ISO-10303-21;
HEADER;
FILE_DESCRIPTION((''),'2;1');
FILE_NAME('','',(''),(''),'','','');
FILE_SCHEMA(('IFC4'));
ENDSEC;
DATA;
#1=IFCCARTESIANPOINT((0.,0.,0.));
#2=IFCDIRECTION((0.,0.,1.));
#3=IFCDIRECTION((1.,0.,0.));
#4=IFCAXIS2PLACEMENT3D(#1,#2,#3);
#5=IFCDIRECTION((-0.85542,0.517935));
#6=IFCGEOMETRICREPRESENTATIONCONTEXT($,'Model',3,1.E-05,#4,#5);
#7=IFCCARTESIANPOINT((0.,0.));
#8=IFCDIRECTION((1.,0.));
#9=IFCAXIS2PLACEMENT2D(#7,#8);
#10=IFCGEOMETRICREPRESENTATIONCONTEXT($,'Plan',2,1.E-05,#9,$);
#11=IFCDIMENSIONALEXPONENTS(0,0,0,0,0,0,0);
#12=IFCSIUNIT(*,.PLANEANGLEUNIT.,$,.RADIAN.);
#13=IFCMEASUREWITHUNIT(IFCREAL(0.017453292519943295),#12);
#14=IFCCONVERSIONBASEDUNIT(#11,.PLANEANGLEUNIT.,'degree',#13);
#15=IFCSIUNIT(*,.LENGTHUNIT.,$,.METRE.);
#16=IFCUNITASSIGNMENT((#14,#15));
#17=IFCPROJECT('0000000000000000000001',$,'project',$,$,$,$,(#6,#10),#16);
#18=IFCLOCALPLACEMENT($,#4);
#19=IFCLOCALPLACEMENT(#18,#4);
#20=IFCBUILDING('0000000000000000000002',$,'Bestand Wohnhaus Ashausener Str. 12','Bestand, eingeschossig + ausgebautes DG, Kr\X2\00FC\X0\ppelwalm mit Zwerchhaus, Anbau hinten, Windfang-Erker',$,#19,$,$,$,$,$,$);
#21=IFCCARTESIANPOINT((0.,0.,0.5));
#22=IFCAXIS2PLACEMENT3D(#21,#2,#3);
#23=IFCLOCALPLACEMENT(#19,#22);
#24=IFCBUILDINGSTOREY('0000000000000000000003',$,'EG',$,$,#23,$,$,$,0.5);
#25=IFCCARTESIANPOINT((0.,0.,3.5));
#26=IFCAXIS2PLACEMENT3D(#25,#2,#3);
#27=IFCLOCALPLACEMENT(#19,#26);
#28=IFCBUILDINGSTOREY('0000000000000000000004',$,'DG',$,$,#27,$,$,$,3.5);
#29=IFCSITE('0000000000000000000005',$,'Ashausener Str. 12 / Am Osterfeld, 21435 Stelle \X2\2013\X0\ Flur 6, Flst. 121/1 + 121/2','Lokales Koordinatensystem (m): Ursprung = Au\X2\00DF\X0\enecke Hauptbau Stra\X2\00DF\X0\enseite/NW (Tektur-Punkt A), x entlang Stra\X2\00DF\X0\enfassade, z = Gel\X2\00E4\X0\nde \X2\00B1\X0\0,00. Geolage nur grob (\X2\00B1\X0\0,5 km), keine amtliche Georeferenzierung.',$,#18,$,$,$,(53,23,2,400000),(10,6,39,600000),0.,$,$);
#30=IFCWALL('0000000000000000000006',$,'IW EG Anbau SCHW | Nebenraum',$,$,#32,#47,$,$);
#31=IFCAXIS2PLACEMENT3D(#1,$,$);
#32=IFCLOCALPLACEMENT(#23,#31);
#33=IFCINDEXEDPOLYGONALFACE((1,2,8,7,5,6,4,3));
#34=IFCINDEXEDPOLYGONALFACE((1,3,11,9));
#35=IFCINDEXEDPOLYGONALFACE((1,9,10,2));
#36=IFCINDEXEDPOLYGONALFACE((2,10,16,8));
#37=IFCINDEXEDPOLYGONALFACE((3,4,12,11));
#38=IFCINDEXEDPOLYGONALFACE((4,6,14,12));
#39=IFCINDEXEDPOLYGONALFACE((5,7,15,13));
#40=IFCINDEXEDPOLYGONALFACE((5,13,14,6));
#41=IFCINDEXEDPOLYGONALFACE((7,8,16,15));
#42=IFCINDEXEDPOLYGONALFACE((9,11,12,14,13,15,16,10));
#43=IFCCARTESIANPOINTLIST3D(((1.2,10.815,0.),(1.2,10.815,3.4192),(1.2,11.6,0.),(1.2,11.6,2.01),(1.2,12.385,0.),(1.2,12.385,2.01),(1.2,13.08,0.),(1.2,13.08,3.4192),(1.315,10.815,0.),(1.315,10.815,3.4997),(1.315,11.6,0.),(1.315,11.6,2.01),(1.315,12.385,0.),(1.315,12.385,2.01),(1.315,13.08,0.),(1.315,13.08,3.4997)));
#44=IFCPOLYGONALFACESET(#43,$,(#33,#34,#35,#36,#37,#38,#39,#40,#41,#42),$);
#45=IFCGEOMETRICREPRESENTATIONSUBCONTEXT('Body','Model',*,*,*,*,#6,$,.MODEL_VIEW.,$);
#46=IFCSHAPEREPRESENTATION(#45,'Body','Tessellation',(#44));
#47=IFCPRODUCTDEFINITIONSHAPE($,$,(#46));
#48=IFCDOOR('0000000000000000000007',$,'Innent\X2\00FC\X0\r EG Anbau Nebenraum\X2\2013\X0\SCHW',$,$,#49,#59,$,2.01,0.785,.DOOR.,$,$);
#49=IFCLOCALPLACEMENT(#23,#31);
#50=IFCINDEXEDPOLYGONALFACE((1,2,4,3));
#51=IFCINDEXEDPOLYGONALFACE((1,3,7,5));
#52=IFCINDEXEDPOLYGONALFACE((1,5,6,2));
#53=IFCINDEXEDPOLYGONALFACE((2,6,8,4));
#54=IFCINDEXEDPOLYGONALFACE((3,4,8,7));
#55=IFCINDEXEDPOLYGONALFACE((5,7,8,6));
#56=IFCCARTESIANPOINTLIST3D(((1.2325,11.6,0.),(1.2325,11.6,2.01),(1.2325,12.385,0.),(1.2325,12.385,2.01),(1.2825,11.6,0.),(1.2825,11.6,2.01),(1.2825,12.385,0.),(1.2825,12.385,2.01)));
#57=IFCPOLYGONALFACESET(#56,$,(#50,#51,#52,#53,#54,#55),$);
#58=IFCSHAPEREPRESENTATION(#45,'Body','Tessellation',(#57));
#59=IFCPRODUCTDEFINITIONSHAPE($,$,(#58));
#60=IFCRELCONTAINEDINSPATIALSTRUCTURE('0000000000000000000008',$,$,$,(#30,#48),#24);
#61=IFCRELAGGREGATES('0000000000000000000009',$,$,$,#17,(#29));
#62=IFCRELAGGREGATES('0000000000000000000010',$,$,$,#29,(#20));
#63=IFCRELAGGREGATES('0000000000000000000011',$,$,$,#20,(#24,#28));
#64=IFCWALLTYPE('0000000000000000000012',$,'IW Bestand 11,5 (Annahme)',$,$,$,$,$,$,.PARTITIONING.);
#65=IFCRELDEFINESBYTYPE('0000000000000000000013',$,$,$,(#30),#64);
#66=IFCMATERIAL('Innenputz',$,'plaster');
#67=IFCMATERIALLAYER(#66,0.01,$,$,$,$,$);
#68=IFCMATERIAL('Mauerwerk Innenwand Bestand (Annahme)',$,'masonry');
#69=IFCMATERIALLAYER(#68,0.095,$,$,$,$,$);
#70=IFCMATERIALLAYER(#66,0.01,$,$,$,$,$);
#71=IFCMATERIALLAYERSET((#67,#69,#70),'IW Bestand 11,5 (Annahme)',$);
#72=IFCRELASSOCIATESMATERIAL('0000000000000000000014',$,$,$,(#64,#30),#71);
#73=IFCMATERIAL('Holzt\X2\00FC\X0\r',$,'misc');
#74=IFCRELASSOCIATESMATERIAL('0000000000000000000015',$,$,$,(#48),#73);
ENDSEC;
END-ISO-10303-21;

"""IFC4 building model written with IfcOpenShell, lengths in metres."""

from ifc_helpers import new_model, entity, si_unit, converted_unit, direction, frame, origin_with_axes, origin_2d_with_axis, place, context, subcontext, project, spatial, indexed_curve, outline, extrude, clip, halfspace, material, layer, layer_set, layer_usage, type_object, element, fill, save


model = new_model("IFC4")

# Units and contexts
model_context = context("Model", 3, precision=1e-05, world=origin_with_axes(), true_north=direction((-0.85542, 0.517935)))
plan_context = context("Plan", 2, precision=1e-05, world=origin_2d_with_axis())
body_context = subcontext(model_context, "Body", "Model", "MODEL_VIEW")
ifc_project = project(units=[converted_unit("PLANEANGLEUNIT", "degree", entity("IfcReal", 0.017453292519943295), si_unit("PLANEANGLEUNIT", "RADIAN"), dimensions=[0, 0, 0, 0, 0, 0, 0]), si_unit("LENGTHUNIT", "METRE")], contexts=[model_context, plan_context])

# Site, building, storey
site_placement = place(None, origin_with_axes())
site = spatial("IfcSite", under=ifc_project, at=site_placement, Name="Ashausener Str. 12 / Am Osterfeld, 21435 Stelle – Flur 6, Flst. 121/1 + 121/2", Description="Lokales Koordinatensystem (m): Ursprung = Außenecke Hauptbau Straßenseite/NW (Tektur-Punkt A), x entlang Straßenfassade, z = Gelände ±0,00. Geolage nur grob (±0,5 km), keine amtliche Georeferenzierung.", RefLatitude=(53, 23, 2, 400000), RefLongitude=(10, 6, 39, 600000), RefElevation=0.0)
building_placement = place(site_placement, origin_with_axes())
building = spatial("IfcBuilding", under=site, at=building_placement, Name="Bestand Wohnhaus Ashausener Str. 12", Description="Bestand, eingeschossig + ausgebautes DG, Krüppelwalm mit Zwerchhaus, Anbau hinten, Windfang-Erker")
storey_1_placement = place(building_placement, frame((0.0, 0.0, 0.5), z_axis=(0.0, 0.0, 1.0), x_axis=(1.0, 0.0, 0.0)))
storey_1 = spatial("IfcBuildingStorey", under=building, at=storey_1_placement, Name="EG", Elevation=0.5)

# Shared definitions
storey_2_placement = place(building_placement, frame((0.0, 0.0, 3.5), z_axis=(0.0, 0.0, 1.0), x_axis=(1.0, 0.0, 0.0)))
storey_2 = spatial("IfcBuildingStorey", under=building, at=storey_2_placement, Name="DG", Elevation=3.5)

# Wall, opening, door
ifc_material_1 = material(Name="Innenputz", Category="plaster")
ifc_layer_1 = layer(ifc_material_1, 0.01)
ifc_material_2 = material(Name="Mauerwerk Innenwand Bestand (Annahme)", Category="masonry")
ifc_layer_2 = layer(ifc_material_2, 0.095)
ifc_layer_3 = layer(ifc_material_1, 0.01)
ifc_layer_set_1 = layer_set([ifc_layer_1, ifc_layer_2, ifc_layer_3], Name="IW Bestand 11,5 (Annahme)")
wall_type_1 = type_object("IfcWallType", Name="IW Bestand 11,5 (Annahme)", PredefinedType="PARTITIONING", material=ifc_layer_set_1)
ifc_material_3 = material(Name="Holztür", Category="misc")
ifc_layer_usage_1 = layer_usage(ifc_layer_set_1, "AXIS2", "POSITIVE", 0.0)
wall_1_placement = place(storey_1_placement, frame((1.2, 13.08, 0.0), z_axis=(0.0, 0.0, 1.0), x_axis=(0.0, -1.0, 0.0)))
wall_1 = element("IfcWall", 1, at=wall_1_placement, inside=storey_1, type_object=wall_type_1, material=ifc_layer_usage_1, Name="IW EG Anbau SCHW | Nebenraum", context=body_context, shape_type="Clipping", body=[
    clip(clip(extrude(outline(indexed_curve([(0.0, 0.0), (0.0, 0.115), (2.265, 0.115), (2.265, 0.0), (0.0, 0.0)], self_intersect=False)), origin_with_axes(), (0.0, 0.0, 1.0), 8.0), halfspace(frame((13.08, 2.9753, 2.3862), z_axis=(0.0, 0.57358, 0.81915), x_axis=(1.0, 0.0, 0.0)), False)), halfspace(frame((13.08, -1.4753, 2.3862), z_axis=(0.0, -0.57358, 0.81915), x_axis=(-1.0, 0.0, 0.0)), False)),
])
opening_1_placement = place(wall_1_placement, frame((0.695, -0.1, 0.0), z_axis=(0.0, 0.0, 1.0), x_axis=(1.0, 0.0, 0.0)))
opening_1 = element("IfcOpeningElement", 2, at=opening_1_placement, cuts=wall_1, context=body_context, shape_type="SweptSolid", body=[
    extrude(outline(indexed_curve([(0.0, 0.0), (0.0, 0.315), (0.785, 0.315), (0.785, 0.0), (0.0, 0.0)], self_intersect=False)), origin_with_axes(), (0.0, 0.0, 1.0), 2.01),
])
door_1_placement = place(storey_1_placement, frame((1.2325, 12.385, 0.0), z_axis=(0.0, 0.0, 1.0), x_axis=(0.0, -1.0, 0.0)))
door_1 = element("IfcDoor", 3, at=door_1_placement, inside=storey_1, material=ifc_material_3, Name="Innentür EG Anbau Nebenraum–SCHW", OverallHeight=2.01, OverallWidth=0.785, PredefinedType="DOOR", context=body_context, shape_type="SweptSolid", body=[
    extrude(outline(indexed_curve([(0.0, 0.0), (0.0, 0.05), (0.785, 0.05), (0.785, 0.0), (0.0, 0.0)], self_intersect=False)), origin_with_axes(), (0.0, 0.0, 1.0), 2.01),
])
fill(opening_1, door_1)

save(model, "model.ifc")
